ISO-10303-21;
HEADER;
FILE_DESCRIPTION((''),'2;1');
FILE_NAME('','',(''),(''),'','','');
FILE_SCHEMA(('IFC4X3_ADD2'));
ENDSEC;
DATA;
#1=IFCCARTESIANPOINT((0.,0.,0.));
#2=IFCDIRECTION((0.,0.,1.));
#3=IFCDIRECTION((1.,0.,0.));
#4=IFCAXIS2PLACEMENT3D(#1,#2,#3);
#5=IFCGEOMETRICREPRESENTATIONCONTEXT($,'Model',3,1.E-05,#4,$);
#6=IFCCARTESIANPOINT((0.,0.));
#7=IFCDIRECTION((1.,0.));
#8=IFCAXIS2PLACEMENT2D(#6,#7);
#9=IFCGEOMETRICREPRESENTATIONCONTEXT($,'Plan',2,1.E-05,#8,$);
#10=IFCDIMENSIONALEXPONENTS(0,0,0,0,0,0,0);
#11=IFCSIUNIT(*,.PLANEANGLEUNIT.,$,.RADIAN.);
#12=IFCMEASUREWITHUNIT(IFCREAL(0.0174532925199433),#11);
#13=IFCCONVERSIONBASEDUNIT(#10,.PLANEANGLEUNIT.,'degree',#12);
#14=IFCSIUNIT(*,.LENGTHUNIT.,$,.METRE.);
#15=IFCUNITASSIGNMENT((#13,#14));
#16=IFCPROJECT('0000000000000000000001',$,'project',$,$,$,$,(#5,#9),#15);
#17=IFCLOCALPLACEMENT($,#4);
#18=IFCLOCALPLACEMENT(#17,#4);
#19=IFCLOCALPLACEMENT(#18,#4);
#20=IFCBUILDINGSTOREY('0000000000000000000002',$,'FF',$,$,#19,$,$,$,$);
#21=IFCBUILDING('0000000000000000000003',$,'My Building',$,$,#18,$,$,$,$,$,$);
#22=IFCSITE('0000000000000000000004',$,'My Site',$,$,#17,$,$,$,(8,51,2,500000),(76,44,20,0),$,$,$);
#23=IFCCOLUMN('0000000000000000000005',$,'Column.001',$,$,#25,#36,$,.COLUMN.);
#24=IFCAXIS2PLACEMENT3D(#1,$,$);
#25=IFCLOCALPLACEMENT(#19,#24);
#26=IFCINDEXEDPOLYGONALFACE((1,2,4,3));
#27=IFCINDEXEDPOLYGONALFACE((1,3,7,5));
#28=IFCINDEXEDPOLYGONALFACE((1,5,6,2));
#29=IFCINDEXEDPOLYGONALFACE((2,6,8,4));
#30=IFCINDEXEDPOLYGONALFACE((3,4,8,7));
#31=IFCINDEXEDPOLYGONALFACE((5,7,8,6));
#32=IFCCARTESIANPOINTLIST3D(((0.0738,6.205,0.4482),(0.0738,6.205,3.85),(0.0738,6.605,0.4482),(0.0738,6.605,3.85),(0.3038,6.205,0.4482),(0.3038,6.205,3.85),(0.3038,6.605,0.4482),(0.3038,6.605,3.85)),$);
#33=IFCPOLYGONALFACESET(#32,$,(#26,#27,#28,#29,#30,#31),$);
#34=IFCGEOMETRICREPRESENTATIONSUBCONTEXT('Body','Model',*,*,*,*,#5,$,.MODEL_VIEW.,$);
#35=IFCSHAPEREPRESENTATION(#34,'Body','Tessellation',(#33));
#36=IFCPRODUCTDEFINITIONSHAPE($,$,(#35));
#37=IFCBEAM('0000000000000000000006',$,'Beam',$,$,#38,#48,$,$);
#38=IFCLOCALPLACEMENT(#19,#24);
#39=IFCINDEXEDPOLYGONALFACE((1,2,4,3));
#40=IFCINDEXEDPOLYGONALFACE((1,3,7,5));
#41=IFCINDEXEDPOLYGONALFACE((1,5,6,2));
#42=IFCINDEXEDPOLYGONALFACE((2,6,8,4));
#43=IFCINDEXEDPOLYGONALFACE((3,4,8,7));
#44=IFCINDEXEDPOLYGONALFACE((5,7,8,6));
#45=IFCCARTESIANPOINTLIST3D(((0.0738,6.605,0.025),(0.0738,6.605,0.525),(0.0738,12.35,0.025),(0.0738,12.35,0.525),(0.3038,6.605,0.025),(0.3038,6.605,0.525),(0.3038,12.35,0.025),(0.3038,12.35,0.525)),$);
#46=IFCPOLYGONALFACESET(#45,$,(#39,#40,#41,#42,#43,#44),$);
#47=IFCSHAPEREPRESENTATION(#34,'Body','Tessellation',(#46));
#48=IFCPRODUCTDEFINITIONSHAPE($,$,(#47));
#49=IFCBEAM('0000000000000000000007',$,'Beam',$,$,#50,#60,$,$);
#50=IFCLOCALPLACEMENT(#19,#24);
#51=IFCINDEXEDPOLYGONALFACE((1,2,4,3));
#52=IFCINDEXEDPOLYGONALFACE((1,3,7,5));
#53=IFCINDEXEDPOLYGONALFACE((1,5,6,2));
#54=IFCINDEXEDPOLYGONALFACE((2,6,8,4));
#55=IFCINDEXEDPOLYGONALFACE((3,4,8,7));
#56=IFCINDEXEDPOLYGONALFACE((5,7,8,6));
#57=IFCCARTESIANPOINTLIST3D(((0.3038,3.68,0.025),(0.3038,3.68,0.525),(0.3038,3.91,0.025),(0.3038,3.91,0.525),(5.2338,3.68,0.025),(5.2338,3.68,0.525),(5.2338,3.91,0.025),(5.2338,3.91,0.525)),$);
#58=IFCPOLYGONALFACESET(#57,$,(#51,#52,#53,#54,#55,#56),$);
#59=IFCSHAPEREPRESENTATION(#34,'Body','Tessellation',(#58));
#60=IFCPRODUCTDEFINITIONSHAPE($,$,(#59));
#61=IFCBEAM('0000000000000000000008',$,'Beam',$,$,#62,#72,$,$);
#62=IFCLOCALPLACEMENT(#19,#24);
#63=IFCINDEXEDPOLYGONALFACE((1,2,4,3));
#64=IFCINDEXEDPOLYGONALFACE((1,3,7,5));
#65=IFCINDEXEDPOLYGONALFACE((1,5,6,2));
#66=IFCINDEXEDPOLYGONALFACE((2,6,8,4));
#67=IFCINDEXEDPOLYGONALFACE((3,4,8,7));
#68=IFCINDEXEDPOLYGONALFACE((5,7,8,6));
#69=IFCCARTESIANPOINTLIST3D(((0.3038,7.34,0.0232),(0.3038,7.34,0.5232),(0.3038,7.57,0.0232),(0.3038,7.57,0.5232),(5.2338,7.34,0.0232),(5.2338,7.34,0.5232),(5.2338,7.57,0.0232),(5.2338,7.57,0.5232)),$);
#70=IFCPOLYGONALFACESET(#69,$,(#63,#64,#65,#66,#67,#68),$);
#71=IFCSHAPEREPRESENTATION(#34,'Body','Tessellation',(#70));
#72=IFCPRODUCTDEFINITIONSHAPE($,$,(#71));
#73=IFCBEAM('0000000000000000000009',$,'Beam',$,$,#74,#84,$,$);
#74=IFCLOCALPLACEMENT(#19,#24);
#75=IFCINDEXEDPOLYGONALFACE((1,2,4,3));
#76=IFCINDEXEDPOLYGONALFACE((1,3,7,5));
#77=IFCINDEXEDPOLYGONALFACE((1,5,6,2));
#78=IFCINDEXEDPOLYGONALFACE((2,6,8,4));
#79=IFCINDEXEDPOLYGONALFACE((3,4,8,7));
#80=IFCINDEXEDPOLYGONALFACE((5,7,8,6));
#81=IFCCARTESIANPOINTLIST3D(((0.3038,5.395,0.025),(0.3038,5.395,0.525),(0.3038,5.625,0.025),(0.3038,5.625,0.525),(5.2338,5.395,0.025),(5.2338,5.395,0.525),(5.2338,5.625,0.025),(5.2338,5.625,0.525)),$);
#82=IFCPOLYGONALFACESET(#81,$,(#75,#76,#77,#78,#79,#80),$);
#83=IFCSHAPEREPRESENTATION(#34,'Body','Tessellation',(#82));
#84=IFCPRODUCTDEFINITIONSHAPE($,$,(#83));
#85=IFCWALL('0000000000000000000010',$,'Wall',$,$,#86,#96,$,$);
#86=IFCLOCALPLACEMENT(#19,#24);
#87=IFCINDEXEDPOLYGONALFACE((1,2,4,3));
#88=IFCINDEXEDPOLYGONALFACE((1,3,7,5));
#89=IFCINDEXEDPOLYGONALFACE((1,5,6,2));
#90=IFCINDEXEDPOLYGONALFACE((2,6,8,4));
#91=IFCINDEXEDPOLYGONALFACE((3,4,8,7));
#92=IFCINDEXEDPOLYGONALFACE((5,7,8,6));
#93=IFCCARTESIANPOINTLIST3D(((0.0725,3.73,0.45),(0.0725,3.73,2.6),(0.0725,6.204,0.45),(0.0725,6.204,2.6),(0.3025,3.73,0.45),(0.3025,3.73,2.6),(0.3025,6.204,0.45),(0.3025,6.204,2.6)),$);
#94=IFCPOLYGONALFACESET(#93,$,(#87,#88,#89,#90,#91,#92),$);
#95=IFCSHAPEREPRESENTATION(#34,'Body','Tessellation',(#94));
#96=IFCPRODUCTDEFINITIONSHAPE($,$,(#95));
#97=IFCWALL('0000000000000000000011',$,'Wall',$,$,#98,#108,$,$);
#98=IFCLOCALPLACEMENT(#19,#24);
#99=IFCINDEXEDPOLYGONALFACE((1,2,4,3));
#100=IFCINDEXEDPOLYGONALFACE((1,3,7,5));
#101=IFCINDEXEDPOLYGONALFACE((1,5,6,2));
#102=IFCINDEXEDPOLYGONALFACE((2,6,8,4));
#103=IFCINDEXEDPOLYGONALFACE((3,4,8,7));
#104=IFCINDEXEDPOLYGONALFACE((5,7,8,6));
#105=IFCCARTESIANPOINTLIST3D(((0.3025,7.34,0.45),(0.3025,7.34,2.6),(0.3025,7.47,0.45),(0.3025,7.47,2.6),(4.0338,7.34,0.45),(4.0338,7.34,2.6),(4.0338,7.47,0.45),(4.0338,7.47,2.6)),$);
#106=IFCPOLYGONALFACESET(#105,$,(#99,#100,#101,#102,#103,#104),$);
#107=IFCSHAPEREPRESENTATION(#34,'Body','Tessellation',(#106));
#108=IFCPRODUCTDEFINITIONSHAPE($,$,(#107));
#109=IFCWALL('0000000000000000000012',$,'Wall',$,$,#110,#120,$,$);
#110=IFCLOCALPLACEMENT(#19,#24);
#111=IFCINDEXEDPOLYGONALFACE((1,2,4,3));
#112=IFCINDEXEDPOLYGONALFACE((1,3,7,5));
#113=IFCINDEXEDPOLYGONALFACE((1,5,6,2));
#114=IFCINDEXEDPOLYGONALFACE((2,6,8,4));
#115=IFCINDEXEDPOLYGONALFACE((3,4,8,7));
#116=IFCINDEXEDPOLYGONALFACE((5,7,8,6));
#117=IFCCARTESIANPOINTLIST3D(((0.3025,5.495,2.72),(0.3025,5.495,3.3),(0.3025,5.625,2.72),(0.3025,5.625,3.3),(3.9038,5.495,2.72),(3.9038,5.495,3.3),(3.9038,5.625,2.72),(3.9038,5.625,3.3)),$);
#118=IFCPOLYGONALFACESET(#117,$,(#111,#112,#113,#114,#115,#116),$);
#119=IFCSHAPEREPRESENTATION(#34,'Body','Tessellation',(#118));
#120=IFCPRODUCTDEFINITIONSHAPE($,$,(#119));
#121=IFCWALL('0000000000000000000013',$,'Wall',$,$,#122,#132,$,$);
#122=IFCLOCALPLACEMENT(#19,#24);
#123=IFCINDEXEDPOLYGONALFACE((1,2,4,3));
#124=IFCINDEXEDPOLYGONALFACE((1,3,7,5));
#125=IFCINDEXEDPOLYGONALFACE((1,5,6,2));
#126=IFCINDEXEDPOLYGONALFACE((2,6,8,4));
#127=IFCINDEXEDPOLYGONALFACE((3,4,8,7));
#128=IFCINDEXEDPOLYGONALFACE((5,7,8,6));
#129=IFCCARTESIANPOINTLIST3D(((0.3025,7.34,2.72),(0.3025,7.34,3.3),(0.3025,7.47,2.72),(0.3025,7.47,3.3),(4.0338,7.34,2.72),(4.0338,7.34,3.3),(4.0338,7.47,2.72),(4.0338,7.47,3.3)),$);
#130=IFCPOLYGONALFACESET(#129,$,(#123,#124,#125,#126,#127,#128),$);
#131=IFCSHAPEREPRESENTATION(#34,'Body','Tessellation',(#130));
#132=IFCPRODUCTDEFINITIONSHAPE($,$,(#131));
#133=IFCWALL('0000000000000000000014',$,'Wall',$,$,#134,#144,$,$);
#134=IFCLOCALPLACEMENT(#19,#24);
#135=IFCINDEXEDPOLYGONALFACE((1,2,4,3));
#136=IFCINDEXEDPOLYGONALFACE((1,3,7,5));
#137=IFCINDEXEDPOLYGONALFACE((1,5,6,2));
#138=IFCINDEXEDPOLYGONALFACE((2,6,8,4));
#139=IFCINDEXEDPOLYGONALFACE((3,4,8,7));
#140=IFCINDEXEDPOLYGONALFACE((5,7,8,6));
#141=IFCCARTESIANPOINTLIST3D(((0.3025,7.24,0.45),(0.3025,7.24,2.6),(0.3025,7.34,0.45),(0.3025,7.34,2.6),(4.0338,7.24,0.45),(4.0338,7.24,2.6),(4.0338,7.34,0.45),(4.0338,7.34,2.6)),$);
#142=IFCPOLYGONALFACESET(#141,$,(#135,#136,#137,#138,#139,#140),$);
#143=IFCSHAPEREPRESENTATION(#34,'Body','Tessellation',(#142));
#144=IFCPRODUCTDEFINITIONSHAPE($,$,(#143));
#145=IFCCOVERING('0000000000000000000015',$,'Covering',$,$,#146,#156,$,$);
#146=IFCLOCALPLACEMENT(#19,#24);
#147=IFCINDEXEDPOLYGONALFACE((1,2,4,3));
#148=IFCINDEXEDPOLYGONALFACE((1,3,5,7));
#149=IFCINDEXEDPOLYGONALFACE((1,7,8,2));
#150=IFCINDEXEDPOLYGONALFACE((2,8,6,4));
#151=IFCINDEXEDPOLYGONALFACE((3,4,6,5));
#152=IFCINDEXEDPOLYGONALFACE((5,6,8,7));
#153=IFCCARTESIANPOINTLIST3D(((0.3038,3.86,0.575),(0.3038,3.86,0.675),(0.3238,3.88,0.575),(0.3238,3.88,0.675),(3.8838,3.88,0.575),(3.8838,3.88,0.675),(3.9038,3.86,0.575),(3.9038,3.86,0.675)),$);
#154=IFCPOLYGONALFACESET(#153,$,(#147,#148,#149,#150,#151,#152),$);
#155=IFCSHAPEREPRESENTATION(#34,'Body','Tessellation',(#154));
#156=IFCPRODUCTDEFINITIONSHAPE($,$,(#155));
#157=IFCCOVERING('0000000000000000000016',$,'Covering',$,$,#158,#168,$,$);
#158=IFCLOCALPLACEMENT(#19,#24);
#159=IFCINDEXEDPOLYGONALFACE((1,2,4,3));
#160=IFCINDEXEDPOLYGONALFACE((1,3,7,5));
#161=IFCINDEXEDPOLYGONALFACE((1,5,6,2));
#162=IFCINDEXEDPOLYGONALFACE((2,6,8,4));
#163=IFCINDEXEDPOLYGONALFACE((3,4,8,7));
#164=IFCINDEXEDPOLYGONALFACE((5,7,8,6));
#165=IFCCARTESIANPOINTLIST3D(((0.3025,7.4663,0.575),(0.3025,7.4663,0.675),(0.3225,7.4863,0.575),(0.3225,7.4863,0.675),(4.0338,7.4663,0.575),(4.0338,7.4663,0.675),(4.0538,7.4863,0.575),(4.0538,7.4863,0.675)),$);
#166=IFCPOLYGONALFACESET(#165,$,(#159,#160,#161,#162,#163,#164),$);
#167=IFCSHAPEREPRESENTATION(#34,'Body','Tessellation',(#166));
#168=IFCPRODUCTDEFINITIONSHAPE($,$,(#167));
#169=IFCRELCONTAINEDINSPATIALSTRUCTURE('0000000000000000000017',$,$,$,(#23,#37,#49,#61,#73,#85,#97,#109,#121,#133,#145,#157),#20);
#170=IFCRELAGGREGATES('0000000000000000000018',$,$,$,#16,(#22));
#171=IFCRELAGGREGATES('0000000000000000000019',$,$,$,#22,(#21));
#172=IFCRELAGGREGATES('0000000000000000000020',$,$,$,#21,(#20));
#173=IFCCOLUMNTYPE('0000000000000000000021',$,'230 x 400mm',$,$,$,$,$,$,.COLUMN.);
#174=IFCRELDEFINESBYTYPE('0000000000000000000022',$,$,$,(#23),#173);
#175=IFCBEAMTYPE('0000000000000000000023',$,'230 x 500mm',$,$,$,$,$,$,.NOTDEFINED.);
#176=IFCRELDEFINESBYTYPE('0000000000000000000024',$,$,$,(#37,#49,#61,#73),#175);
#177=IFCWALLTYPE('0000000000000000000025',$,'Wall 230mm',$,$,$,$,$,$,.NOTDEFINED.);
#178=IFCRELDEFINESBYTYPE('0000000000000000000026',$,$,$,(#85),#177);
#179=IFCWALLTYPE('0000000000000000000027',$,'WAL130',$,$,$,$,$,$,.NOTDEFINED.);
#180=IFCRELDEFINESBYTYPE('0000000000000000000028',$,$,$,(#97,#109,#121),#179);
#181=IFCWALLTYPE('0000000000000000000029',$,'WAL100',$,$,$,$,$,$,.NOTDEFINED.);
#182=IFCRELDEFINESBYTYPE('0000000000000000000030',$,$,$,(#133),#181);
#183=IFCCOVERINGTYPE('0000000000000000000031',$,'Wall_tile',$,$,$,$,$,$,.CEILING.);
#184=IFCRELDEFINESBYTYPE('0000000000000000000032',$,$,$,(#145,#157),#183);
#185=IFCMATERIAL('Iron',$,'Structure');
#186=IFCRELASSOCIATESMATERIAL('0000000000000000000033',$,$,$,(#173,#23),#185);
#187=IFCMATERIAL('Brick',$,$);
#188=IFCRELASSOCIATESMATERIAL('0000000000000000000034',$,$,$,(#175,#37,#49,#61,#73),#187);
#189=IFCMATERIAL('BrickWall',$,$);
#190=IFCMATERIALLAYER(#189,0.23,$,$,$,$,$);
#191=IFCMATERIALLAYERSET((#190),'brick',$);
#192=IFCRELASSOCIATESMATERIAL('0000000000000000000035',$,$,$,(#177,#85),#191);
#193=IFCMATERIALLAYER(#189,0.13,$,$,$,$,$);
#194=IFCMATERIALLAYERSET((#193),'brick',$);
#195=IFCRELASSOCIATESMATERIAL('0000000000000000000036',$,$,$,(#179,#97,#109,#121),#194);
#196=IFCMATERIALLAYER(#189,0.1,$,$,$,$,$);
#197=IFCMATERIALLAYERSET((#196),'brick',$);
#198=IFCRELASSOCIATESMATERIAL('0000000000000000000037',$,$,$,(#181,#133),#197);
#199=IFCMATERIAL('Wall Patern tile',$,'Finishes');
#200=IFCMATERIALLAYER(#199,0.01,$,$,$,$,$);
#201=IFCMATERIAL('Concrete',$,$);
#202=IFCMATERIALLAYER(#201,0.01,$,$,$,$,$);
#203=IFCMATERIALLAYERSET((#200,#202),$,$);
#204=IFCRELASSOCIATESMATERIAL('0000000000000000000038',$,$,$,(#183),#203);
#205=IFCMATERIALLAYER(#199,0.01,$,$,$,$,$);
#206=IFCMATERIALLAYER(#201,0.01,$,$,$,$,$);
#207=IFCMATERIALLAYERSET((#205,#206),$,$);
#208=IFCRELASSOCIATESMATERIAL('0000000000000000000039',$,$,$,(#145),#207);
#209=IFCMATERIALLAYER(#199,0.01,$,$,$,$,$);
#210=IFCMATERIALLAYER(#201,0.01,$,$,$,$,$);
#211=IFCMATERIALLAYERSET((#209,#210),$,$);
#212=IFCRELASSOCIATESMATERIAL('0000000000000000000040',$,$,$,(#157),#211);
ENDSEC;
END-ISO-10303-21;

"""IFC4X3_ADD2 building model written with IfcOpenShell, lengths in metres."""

from ifc_helpers import new_model, entity, si_unit, converted_unit, frame, origin_with_axes, origin_2d_with_axis, place, context, subcontext, project, spatial, line, indexed_curve, rectangle, outline, extrude, material, layer, layer_set, layer_usage, material_profile, profile_set, profile_usage, type_object, element, save


model = new_model("IFC4X3_ADD2")

# Units and contexts
model_context = context("Model", 3, precision=1e-05, world=origin_with_axes())
plan_context = context("Plan", 2, precision=1e-05, world=origin_2d_with_axis())
body_context_1 = subcontext(model_context, "Body", "Model", "MODEL_VIEW")
ifc_project = project(units=[converted_unit("PLANEANGLEUNIT", "degree", entity("IfcReal", 0.0174532925199433), si_unit("PLANEANGLEUNIT", "RADIAN"), dimensions=[0, 0, 0, 0, 0, 0, 0]), si_unit("LENGTHUNIT", "METRE")], contexts=[model_context, plan_context])

# Site, building, storey
site_placement = place(None, origin_with_axes())
site = spatial("IfcSite", under=ifc_project, at=site_placement, Name="My Site", RefLatitude=(8, 51, 2, 500000), RefLongitude=(76, 44, 20, 0))
building_placement = place(site_placement, origin_with_axes())
building = spatial("IfcBuilding", under=site, at=building_placement, Name="My Building")
storey_placement = place(building_placement, origin_with_axes())
storey = spatial("IfcBuildingStorey", under=building, at=storey_placement, Name="FF")

# Column
ifc_material_1 = material(Name="Iron", Category="Structure")
ifc_material_profile_1 = material_profile(ifc_material_1, outline(indexed_curve([(-0.115, 0.2), (0.115, 0.2), (0.115, -0.2), (-0.115, -0.2), (-0.115, 0.2)])))
ifc_profile_set_1 = profile_set([ifc_material_profile_1])
ifc_profile_usage_1 = profile_usage(ifc_profile_set_1)
column_type = type_object("IfcColumnType", Name="230 x 400mm", PredefinedType="COLUMN", material=ifc_profile_set_1)
column_placement = place(storey_placement, frame((0.1888, 6.405, 0.4482), z_axis=(0.0, 0.0, 1.0), x_axis=(1.0, 0.0, 0.0)))
element("IfcColumn", 1, at=column_placement, inside=storey, type_object=column_type, material=ifc_profile_usage_1, Name="Column.001", PredefinedType="COLUMN", context=body_context_1, shape_type="SweptSolid", body=[
    extrude(outline(indexed_curve([(-0.115, 0.2), (0.115, 0.2), (0.115, -0.2), (-0.115, -0.2), (-0.115, 0.2)])), origin_with_axes(), (0.0, 0.0, 1.0), 3.4018),
])

# Beams
ifc_material_2 = material(Name="Brick")
ifc_material_profile_2 = material_profile(ifc_material_2, rectangle(XDim=0.23, YDim=0.5))
ifc_profile_set_2 = profile_set([ifc_material_profile_2], Name="rcc")
ifc_profile_usage_2 = profile_usage(ifc_profile_set_2)
beam_type = type_object("IfcBeamType", Name="230 x 500mm", PredefinedType="NOTDEFINED", material=ifc_profile_set_2)
beam_1_placement = place(storey_placement, frame((0.1888, 6.605, 0.275), z_axis=(0.0, 1.0, 0.0), x_axis=(-1.0, 0.0, 0.0)))
element("IfcBeam", 2, at=beam_1_placement, inside=storey, type_object=beam_type, material=ifc_profile_usage_2, Name="Beam", context=body_context_1, shape_type="SweptSolid", body=[
    extrude(rectangle(XDim=0.23, YDim=0.5), origin_with_axes(), (0.0, 0.0, 1.0), 5.745),
])
ifc_profile_usage_3 = profile_usage(ifc_profile_set_2)
beam_2_placement = place(storey_placement, frame((0.3038, 3.795, 0.275), z_axis=(1.0, 0.0, 0.0), x_axis=(0.0, 1.0, 0.0)))
element("IfcBeam", 3, at=beam_2_placement, inside=storey, type_object=beam_type, material=ifc_profile_usage_3, Name="Beam", context=body_context_1, shape_type="SweptSolid", body=[
    extrude(rectangle(XDim=0.23, YDim=0.5), origin_with_axes(), (0.0, 0.0, 1.0), 4.93),
])
ifc_profile_usage_4 = profile_usage(ifc_profile_set_2)
beam_3_placement = place(storey_placement, frame((0.3038, 7.455, 0.2732), z_axis=(1.0, 0.0, 0.0), x_axis=(0.0, 1.0, 0.0)))
element("IfcBeam", 4, at=beam_3_placement, inside=storey, type_object=beam_type, material=ifc_profile_usage_4, Name="Beam", context=body_context_1, shape_type="SweptSolid", body=[
    extrude(rectangle(XDim=0.23, YDim=0.5), origin_with_axes(), (0.0, 0.0, 1.0), 4.93),
])
ifc_profile_usage_5 = profile_usage(ifc_profile_set_2)
beam_4_placement = place(storey_placement, frame((0.3038, 5.51, 0.275), z_axis=(1.0, 0.0, 0.0), x_axis=(0.0, 1.0, 0.0)))
element("IfcBeam", 5, at=beam_4_placement, inside=storey, type_object=beam_type, material=ifc_profile_usage_5, Name="Beam", context=body_context_1, shape_type="SweptSolid", body=[
    extrude(rectangle(XDim=0.23, YDim=0.5), origin_with_axes(), (0.0, 0.0, 1.0), 4.93),
])

# Wall
ifc_material_3 = material(Name="BrickWall")
ifc_layer_1 = layer(ifc_material_3, 0.23)
ifc_layer_set_1 = layer_set([ifc_layer_1], Name="brick")
ifc_layer_usage_1 = layer_usage(ifc_layer_set_1, "AXIS2", "POSITIVE", 0.0)
wall_type_1 = type_object("IfcWallType", Name="Wall 230mm", PredefinedType="NOTDEFINED", material=ifc_layer_set_1)
wall_1_placement = place(storey_placement, frame((0.3025, 3.73, 0.45), z_axis=(0.0, 0.0, 1.0), x_axis=(0.0, 1.0, 0.0)))
element("IfcWall", 6, at=wall_1_placement, inside=storey, type_object=wall_type_1, material=ifc_layer_usage_1, Name="Wall", context=body_context_1, shape_type="SweptSolid", body=[
    extrude(outline(indexed_curve([(0.0, 0.0), (0.0, 0.23), (2.474, 0.23), (2.474, 0.0)], segments=[line(1, 2, 3, 4, 1)])), origin_with_axes(), (0.0, 0.0, 1.0), 2.15),
])

# Wall
ifc_layer_2 = layer(ifc_material_3, 0.13)
ifc_layer_set_2 = layer_set([ifc_layer_2], Name="brick")
ifc_layer_usage_2 = layer_usage(ifc_layer_set_2, "AXIS2", "POSITIVE", 0.0)
wall_type_2 = type_object("IfcWallType", Name="WAL130", PredefinedType="NOTDEFINED", material=ifc_layer_set_2)
wall_2_placement = place(storey_placement, frame((0.3025, 7.34, 0.45), z_axis=(0.0, 0.0, 1.0), x_axis=(1.0, 0.0, 0.0)))
element("IfcWall", 7, at=wall_2_placement, inside=storey, type_object=wall_type_2, material=ifc_layer_usage_2, Name="Wall", context=body_context_1, shape_type="SweptSolid", body=[
    extrude(outline(indexed_curve([(0.0, 0.0), (0.0, 0.13), (3.7313, 0.13), (3.7313, 0.0), (0.0, 0.0)], self_intersect=False)), origin_with_axes(), (0.0, 0.0, 1.0), 2.15),
])

# Walls
ifc_layer_usage_3 = layer_usage(ifc_layer_set_2, "AXIS2", "POSITIVE", 0.0)
wall_3_placement = place(storey_placement, frame((0.3025, 5.495, 2.72), z_axis=(0.0, 0.0, 1.0), x_axis=(1.0, 0.0, 0.0)))
element("IfcWall", 8, at=wall_3_placement, inside=storey, type_object=wall_type_2, material=ifc_layer_usage_3, Name="Wall", context=body_context_1, shape_type="SweptSolid", body=[
    extrude(outline(indexed_curve([(0.0, 0.0), (0.0, 0.13), (3.6013, 0.13), (3.6013, 0.0)], segments=[line(1, 2, 3, 4, 1)])), origin_with_axes(), (0.0, 0.0, 1.0), 0.58),
])
ifc_layer_usage_4 = layer_usage(ifc_layer_set_2, "AXIS2", "POSITIVE", 0.0)
wall_4_placement = place(storey_placement, frame((0.3025, 7.34, 2.72), z_axis=(0.0, 0.0, 1.0), x_axis=(1.0, 0.0, 0.0)))
element("IfcWall", 9, at=wall_4_placement, inside=storey, type_object=wall_type_2, material=ifc_layer_usage_4, Name="Wall", context=body_context_1, shape_type="SweptSolid", body=[
    extrude(outline(indexed_curve([(0.0, 0.0), (0.0, 0.13), (3.7313, 0.13), (3.7313, 0.0), (0.0, 0.0)], self_intersect=False)), origin_with_axes(), (0.0, 0.0, 1.0), 0.58),
])
ifc_layer_3 = layer(ifc_material_3, 0.1)
ifc_layer_set_3 = layer_set([ifc_layer_3], Name="brick")
ifc_layer_usage_5 = layer_usage(ifc_layer_set_3, "AXIS2", "POSITIVE", 0.0)
wall_type_3 = type_object("IfcWallType", Name="WAL100", PredefinedType="NOTDEFINED", material=ifc_layer_set_3)
wall_5_placement = place(storey_placement, frame((0.3025, 7.24, 0.45), z_axis=(0.0, 0.0, 1.0), x_axis=(1.0, 0.0, 0.0)))
element("IfcWall", 10, at=wall_5_placement, inside=storey, type_object=wall_type_3, material=ifc_layer_usage_5, Name="Wall", context=body_context_1, shape_type="SweptSolid", body=[
    extrude(outline(indexed_curve([(0.0, 0.0), (0.0, 0.1), (3.7313, 0.1), (3.7313, 0.0)], segments=[line(1, 2, 3, 4, 1)])), origin_with_axes(), (0.0, 0.0, 1.0), 2.15),
])

# Coverings
ifc_material_4 = material(Name="Wall Patern tile", Category="Finishes")
ifc_layer_4 = layer(ifc_material_4, 0.01)
ifc_material_5 = material(Name="Concrete")
ifc_layer_5 = layer(ifc_material_5, 0.01)
ifc_layer_set_4 = layer_set([ifc_layer_4, ifc_layer_5])
ifc_layer_usage_6 = layer_usage(ifc_layer_set_4, "AXIS2", "NEGATIVE", 0.0)
ifc_layer_6 = layer(ifc_material_4, 0.01)
ifc_layer_7 = layer(ifc_material_5, 0.01)
ifc_layer_set_5 = layer_set([ifc_layer_6, ifc_layer_7])
covering_type_1 = type_object("IfcCoveringType", Name="Wall_tile", PredefinedType="CEILING", material=ifc_layer_set_5)
covering_1_placement = place(storey_placement, frame((0.3238, 3.88, 0.575), z_axis=(0.0, 0.0, 1.0), x_axis=(1.0, 0.0, 0.0)))
element("IfcCovering", 11, at=covering_1_placement, inside=storey, type_object=covering_type_1, material=ifc_layer_usage_6, Name="Covering", context=body_context_1, shape_type="SweptSolid", body=[
    extrude(outline(indexed_curve([(-0.02, -0.02), (0.0, 0.0), (3.56, 0.0), (3.58, -0.02)], segments=[line(1, 2, 3, 4, 1)])), origin_with_axes(), (0.0, 0.0, 1.0), 0.1),
])
ifc_layer_8 = layer(ifc_material_4, 0.01)
ifc_layer_9 = layer(ifc_material_5, 0.01)
ifc_layer_set_6 = layer_set([ifc_layer_8, ifc_layer_9])
ifc_layer_usage_7 = layer_usage(ifc_layer_set_6, "AXIS2", "NEGATIVE", 0.0)
covering_2_placement = place(storey_placement, frame((0.3025, 7.4863, 0.575), z_axis=(0.0, 0.0, 1.0), x_axis=(1.0, 0.0, 0.0)))
element("IfcCovering", 12, at=covering_2_placement, inside=storey, type_object=covering_type_1, material=ifc_layer_usage_7, Name="Covering", context=body_context_1, shape_type="SweptSolid", body=[
    extrude(outline(indexed_curve([(0.0, -0.02), (0.02, 0.0), (3.7513, 0.0), (3.7313, -0.02)], segments=[line(1, 2, 3, 4, 1)])), origin_with_axes(), (0.0, 0.0, 1.0), 0.1),
])

save(model, "model.ifc")
